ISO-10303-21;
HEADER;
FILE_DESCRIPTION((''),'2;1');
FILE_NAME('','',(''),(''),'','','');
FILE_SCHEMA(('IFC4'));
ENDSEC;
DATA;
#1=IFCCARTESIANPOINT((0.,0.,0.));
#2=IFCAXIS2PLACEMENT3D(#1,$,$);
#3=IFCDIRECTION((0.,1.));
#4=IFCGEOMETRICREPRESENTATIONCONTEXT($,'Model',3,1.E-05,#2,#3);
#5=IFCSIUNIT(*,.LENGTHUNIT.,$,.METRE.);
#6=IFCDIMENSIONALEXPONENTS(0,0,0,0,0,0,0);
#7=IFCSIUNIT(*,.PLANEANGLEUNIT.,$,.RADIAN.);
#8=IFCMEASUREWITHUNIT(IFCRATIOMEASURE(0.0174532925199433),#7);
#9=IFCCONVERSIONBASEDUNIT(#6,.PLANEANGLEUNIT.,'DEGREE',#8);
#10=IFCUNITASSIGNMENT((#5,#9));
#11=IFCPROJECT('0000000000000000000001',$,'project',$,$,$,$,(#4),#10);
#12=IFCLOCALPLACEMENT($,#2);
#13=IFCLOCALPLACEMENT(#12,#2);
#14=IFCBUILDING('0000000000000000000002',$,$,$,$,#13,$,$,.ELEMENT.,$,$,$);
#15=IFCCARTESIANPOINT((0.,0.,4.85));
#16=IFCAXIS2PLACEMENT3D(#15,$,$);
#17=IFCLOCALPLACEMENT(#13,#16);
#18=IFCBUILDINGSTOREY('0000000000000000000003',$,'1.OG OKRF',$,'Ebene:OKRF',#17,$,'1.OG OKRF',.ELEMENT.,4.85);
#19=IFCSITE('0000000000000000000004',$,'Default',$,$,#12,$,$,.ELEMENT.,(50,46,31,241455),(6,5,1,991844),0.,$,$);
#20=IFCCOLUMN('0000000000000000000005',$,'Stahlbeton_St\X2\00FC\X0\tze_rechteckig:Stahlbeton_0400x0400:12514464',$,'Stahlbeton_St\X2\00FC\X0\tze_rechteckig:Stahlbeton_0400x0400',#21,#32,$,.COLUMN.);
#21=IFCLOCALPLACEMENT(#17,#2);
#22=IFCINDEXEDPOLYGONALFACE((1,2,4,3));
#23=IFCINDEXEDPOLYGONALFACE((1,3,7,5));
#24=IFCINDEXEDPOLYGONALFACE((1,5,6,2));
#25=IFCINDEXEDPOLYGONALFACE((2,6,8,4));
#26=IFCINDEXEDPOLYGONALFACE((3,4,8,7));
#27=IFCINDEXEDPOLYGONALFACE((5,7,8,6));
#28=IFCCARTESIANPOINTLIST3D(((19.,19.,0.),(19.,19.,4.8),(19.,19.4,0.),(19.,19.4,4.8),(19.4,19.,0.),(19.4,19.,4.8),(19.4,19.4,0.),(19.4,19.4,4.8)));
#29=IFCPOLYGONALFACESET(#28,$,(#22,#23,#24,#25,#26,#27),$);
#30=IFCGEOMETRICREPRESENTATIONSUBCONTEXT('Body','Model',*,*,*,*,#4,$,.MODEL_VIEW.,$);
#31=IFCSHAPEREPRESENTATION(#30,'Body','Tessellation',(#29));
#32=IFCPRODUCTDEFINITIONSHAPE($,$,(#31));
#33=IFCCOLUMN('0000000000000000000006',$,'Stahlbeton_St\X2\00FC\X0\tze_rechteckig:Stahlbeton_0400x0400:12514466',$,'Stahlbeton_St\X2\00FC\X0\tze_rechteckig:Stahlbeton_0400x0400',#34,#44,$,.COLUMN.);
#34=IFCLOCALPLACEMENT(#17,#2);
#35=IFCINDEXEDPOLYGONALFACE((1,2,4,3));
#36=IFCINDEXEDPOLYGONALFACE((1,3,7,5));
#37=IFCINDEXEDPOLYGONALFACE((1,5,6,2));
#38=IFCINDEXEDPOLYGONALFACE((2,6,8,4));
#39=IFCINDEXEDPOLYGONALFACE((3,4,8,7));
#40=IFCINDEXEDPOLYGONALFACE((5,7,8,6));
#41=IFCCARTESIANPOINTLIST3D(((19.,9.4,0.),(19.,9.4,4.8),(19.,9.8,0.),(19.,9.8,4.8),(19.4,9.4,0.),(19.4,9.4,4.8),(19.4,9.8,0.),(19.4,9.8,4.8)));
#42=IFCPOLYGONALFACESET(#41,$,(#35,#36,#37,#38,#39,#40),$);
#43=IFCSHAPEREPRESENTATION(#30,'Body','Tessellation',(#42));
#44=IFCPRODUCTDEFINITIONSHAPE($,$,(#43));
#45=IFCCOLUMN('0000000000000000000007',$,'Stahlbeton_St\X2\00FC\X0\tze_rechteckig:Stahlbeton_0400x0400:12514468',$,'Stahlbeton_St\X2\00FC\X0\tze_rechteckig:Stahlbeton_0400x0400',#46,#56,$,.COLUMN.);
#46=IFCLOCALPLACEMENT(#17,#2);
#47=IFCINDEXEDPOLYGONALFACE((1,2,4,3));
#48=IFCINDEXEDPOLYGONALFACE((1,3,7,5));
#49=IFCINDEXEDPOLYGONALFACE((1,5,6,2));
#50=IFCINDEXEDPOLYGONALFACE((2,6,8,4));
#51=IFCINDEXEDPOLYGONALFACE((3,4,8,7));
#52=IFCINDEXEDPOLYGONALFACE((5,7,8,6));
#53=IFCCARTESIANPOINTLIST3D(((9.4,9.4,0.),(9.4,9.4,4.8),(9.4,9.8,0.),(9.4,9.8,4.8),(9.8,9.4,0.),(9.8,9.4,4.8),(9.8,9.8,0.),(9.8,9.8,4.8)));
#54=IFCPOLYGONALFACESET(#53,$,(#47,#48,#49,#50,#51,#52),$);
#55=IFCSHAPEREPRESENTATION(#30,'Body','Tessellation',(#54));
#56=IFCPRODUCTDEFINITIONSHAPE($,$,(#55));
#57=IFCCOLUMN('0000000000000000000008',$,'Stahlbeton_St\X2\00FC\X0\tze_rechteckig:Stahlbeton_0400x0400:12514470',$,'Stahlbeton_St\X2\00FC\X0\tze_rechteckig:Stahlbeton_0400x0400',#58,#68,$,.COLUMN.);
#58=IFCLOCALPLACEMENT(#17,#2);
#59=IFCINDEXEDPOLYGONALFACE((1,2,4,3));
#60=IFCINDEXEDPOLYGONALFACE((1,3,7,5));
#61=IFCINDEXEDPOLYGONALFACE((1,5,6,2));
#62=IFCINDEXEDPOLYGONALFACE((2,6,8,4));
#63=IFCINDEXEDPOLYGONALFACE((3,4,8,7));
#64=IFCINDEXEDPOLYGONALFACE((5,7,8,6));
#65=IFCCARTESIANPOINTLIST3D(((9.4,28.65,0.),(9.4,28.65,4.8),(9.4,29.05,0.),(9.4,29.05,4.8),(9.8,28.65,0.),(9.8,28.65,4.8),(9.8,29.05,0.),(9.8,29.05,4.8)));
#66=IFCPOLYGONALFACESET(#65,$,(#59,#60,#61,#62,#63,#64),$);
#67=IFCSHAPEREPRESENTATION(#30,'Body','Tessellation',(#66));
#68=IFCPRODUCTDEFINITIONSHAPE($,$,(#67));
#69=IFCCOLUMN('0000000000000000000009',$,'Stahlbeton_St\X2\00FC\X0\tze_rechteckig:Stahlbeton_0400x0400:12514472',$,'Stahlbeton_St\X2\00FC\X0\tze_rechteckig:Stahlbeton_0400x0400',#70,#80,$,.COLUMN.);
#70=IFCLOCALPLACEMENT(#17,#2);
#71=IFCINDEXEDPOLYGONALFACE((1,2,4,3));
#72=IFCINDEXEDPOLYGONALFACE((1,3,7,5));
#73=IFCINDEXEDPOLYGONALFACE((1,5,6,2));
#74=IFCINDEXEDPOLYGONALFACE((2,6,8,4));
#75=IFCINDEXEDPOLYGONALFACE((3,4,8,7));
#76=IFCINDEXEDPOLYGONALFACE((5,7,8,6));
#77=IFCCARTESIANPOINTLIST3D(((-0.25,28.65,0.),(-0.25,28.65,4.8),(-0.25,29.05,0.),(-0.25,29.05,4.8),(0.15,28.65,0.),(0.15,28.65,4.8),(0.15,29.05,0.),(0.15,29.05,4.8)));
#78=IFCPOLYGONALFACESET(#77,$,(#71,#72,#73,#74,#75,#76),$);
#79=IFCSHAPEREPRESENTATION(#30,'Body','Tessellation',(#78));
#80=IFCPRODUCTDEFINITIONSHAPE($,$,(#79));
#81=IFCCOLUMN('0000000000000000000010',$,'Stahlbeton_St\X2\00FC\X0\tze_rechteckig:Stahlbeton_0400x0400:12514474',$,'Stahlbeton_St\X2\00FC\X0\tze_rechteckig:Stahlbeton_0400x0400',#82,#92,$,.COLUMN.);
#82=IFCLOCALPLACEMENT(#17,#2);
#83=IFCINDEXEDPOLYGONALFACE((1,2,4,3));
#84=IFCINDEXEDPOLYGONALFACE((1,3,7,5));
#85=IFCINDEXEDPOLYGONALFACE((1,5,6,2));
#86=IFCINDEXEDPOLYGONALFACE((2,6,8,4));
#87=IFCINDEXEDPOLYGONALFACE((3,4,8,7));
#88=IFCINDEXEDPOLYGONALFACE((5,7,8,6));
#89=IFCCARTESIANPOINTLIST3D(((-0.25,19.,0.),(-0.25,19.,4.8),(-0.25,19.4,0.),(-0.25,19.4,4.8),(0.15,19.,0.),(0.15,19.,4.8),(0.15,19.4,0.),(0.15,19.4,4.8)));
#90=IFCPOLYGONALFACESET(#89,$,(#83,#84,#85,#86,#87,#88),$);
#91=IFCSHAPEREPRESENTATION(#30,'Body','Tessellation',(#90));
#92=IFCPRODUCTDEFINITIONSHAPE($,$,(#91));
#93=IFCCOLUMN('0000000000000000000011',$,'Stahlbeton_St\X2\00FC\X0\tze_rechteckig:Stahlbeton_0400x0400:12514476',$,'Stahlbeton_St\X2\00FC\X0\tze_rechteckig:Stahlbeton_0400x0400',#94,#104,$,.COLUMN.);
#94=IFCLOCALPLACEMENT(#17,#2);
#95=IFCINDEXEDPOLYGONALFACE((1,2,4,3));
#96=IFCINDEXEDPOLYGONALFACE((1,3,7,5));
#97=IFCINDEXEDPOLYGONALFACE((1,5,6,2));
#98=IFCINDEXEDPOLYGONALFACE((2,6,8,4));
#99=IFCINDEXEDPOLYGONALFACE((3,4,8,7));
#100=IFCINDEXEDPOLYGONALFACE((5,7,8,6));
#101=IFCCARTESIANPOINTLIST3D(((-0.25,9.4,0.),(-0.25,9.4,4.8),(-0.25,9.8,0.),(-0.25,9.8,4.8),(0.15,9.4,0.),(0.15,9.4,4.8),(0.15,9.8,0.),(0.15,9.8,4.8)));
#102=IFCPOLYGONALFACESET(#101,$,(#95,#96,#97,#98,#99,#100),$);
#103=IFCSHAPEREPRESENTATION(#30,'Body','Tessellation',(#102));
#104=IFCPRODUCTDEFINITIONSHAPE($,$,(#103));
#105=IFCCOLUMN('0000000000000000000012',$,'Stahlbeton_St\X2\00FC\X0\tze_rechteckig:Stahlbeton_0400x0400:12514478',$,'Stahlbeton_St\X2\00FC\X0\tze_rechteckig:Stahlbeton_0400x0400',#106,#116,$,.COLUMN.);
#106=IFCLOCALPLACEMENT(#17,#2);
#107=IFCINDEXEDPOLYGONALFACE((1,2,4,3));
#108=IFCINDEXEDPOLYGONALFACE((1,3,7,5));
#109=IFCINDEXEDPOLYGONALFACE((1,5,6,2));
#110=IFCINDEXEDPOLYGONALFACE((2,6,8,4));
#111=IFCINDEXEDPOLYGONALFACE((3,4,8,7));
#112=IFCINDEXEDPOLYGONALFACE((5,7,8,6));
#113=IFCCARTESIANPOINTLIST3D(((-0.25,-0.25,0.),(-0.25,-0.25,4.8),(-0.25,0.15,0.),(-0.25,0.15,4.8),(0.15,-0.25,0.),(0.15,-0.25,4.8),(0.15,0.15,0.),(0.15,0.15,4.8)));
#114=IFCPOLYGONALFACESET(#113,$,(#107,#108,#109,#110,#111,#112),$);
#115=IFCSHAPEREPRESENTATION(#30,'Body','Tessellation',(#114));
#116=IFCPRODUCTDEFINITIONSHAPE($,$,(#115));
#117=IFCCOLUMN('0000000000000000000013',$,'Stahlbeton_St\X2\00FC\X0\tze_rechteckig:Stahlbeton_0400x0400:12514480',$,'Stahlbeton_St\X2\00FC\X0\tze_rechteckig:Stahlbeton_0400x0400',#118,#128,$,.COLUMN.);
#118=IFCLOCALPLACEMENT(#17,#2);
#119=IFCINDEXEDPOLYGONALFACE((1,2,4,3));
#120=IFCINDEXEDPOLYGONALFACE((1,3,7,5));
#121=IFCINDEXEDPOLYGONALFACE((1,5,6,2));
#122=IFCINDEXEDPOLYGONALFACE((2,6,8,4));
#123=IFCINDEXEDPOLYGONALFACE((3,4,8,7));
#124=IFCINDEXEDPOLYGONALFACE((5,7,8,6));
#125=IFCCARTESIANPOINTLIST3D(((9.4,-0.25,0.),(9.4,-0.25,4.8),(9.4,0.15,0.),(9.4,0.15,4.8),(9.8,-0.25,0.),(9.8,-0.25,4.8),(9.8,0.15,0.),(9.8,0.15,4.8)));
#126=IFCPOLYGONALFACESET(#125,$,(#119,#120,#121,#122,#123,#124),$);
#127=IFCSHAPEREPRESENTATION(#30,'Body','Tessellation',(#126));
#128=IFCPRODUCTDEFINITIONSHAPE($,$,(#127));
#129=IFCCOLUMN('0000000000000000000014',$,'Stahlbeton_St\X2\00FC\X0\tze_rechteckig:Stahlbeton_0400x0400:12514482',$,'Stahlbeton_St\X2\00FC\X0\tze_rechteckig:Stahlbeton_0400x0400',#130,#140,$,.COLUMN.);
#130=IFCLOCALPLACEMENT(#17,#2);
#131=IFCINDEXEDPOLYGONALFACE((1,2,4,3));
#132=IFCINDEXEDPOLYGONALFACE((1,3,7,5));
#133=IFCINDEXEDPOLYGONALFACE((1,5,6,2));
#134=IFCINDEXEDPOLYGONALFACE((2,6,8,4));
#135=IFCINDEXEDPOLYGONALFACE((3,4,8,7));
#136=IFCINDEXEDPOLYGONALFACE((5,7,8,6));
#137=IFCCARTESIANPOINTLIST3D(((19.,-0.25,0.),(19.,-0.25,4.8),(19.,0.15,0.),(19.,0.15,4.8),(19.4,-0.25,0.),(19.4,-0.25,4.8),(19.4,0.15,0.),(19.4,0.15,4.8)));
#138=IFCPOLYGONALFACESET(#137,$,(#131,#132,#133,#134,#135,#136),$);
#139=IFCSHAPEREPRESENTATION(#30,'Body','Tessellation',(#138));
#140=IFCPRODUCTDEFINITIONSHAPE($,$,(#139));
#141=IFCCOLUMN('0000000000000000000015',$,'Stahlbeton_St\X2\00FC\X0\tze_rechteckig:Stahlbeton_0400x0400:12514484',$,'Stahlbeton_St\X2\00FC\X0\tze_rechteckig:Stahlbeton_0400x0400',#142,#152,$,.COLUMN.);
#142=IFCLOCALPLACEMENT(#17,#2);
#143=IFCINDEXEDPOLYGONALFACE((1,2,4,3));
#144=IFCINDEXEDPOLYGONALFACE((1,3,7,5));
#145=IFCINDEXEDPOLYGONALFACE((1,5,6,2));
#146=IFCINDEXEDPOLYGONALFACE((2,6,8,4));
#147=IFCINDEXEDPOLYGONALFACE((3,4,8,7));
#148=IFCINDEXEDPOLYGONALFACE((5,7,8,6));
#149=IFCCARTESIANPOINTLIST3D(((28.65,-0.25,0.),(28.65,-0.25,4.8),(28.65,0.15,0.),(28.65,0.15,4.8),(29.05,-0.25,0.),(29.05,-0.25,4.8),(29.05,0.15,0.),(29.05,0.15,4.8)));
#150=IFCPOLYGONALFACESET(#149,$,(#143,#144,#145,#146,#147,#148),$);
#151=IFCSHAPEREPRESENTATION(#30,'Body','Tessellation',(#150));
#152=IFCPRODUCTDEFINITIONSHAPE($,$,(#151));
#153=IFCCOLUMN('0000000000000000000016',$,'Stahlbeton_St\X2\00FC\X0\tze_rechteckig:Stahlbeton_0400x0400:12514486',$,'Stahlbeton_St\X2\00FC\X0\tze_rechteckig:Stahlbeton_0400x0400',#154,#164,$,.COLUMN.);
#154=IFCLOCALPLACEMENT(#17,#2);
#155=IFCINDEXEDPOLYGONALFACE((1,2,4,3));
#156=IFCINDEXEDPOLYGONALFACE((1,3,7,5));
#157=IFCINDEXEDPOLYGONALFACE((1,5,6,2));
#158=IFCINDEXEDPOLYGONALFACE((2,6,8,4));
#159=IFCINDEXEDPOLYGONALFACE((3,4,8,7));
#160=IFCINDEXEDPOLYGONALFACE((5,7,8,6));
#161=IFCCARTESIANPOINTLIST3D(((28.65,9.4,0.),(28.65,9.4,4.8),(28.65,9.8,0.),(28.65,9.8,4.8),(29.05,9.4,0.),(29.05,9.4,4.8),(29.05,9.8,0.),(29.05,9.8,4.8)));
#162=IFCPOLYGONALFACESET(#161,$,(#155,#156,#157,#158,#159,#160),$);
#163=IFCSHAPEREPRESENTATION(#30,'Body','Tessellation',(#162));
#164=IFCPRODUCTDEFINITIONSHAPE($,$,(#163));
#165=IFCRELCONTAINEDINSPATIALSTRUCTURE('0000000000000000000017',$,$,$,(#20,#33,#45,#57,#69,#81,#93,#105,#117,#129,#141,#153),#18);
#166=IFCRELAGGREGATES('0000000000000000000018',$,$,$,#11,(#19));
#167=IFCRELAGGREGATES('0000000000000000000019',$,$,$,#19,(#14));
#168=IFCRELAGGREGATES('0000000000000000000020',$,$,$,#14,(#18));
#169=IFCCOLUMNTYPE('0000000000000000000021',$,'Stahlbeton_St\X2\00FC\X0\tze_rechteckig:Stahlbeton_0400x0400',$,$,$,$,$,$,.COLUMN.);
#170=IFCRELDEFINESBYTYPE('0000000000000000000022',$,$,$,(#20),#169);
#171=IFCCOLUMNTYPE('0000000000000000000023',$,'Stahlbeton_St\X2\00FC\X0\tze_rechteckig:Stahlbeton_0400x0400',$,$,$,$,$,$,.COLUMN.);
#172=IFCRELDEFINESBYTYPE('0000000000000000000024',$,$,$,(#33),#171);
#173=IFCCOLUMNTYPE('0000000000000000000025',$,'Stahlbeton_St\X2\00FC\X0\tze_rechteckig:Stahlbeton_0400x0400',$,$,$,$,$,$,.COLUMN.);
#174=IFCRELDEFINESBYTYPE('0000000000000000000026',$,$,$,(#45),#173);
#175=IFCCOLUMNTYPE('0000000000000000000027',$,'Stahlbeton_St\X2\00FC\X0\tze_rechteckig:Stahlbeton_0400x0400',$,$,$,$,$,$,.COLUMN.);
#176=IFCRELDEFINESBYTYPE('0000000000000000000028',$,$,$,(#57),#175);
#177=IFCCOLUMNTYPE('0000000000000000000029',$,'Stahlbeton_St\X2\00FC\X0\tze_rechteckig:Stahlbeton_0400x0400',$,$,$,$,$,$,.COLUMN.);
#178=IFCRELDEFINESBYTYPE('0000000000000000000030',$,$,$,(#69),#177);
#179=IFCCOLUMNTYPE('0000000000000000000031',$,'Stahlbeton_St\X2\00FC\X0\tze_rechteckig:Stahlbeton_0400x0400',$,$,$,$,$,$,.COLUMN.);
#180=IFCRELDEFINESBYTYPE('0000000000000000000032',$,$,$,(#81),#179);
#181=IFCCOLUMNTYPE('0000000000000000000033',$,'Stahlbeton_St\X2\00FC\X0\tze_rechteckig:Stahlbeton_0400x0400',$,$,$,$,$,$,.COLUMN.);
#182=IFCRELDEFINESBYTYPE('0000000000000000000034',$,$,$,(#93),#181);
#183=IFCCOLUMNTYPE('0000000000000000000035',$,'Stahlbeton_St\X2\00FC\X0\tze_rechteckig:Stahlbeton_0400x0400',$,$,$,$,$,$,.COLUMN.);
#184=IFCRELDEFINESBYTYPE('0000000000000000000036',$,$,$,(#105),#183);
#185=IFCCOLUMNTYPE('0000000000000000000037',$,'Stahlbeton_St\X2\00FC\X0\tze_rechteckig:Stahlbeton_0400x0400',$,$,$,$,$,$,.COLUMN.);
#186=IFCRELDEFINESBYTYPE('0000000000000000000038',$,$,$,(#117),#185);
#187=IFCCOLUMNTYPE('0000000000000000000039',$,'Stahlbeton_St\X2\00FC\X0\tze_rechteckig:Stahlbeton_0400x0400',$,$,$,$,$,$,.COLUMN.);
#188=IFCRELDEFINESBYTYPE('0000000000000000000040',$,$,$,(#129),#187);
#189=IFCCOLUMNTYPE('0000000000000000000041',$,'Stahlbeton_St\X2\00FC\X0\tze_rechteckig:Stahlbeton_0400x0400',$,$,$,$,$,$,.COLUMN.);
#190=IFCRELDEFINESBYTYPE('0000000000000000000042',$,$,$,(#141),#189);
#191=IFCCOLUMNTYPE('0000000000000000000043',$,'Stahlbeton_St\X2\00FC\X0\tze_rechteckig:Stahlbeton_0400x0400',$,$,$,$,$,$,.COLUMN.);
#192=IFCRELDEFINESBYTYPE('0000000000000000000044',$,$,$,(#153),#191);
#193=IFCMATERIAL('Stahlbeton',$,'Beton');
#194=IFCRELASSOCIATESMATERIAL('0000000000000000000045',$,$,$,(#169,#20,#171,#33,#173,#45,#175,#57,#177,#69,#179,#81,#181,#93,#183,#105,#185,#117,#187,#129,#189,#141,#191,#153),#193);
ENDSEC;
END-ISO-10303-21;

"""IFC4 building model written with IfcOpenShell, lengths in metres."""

from ifc_helpers import new_model, entity, si_unit, converted_unit, direction, frame, origin, place, context, subcontext, project, spatial, indexed_curve, outline, extrude, source, transform, mapped, material, type_object, type_shapes, element, save


model = new_model("IFC4")

# Units and contexts
model_context = context("Model", 3, precision=1e-05, world=origin(), true_north=direction((0.0, 1.0)))
body_context = subcontext(model_context, "Body", "Model", "MODEL_VIEW")
ifc_project = project(units=[si_unit("LENGTHUNIT", "METRE"), converted_unit("PLANEANGLEUNIT", "DEGREE", entity("IfcRatioMeasure", 0.0174532925199433), si_unit("PLANEANGLEUNIT", "RADIAN"), dimensions=[0, 0, 0, 0, 0, 0, 0])], contexts=[model_context])

# Site, building, storey
site_placement = place(None, origin())
site = spatial("IfcSite", under=ifc_project, at=site_placement, Name="Default", CompositionType="ELEMENT", RefLatitude=(50, 46, 31, 241455), RefLongitude=(6, 5, 1, 991844), RefElevation=0.0)
building_placement = place(site_placement, origin())
building = spatial("IfcBuilding", under=site, at=building_placement, CompositionType="ELEMENT")
storey_placement = place(building_placement, frame((0.0, 0.0, 4.85)))
storey = spatial("IfcBuildingStorey", under=building, at=storey_placement, Name="1.OG OKRF", ObjectType="Ebene:OKRF", LongName="1.OG OKRF", CompositionType="ELEMENT", Elevation=4.85)

# Columns
ifc_material_1 = material(Name="Stahlbeton", Category="Beton")
column_type_1 = type_object("IfcColumnType", Name="Stahlbeton_Stütze_rechteckig:Stahlbeton_0400x0400", PredefinedType="COLUMN", material=ifc_material_1)
shared_shape_1 = source(origin(), body_context, "Body", "SweptSolid", [
    extrude(outline(indexed_curve([(-0.2, -0.2), (0.2, -0.2), (0.2, 0.2), (-0.2, 0.2), (-0.2, -0.2)], self_intersect=False)), frame((19.2, 19.2, 4.85), z_axis=(0.0, 0.0, 1.0), x_axis=(0.0, -1.0, 0.0)), (0.0, 0.0, 1.0), 4.8),
])
type_shapes(column_type_1, [shared_shape_1])
column_1_placement = place(storey_placement, frame((0.0, 0.0, -4.85)))
element("IfcColumn", 1, at=column_1_placement, inside=storey, type_object=column_type_1, material=ifc_material_1, Name="Stahlbeton_Stütze_rechteckig:Stahlbeton_0400x0400:12514464", ObjectType="Stahlbeton_Stütze_rechteckig:Stahlbeton_0400x0400", PredefinedType="COLUMN", context=body_context, shape_type="MappedRepresentation", body=[
    mapped(shared_shape_1, transform((0.0, 0.0, 0.0), scale=1.0)),
])
column_type_2 = type_object("IfcColumnType", Name="Stahlbeton_Stütze_rechteckig:Stahlbeton_0400x0400", PredefinedType="COLUMN", material=ifc_material_1)
shared_shape_2 = source(origin(), body_context, "Body", "SweptSolid", [
    extrude(outline(indexed_curve([(-0.2, -0.2), (0.2, -0.2), (0.2, 0.2), (-0.2, 0.2), (-0.2, -0.2)], self_intersect=False)), frame((19.2, 9.6, 4.85), z_axis=(0.0, 0.0, 1.0), x_axis=(0.0, -1.0, 0.0)), (0.0, 0.0, 1.0), 4.8),
])
type_shapes(column_type_2, [shared_shape_2])
column_2_placement = place(storey_placement, frame((0.0, 0.0, -4.85)))
element("IfcColumn", 2, at=column_2_placement, inside=storey, type_object=column_type_2, material=ifc_material_1, Name="Stahlbeton_Stütze_rechteckig:Stahlbeton_0400x0400:12514466", ObjectType="Stahlbeton_Stütze_rechteckig:Stahlbeton_0400x0400", PredefinedType="COLUMN", context=body_context, shape_type="MappedRepresentation", body=[
    mapped(shared_shape_2, transform((0.0, 0.0, 0.0), scale=1.0)),
])
column_type_3 = type_object("IfcColumnType", Name="Stahlbeton_Stütze_rechteckig:Stahlbeton_0400x0400", PredefinedType="COLUMN", material=ifc_material_1)
shared_shape_3 = source(origin(), body_context, "Body", "SweptSolid", [
    extrude(outline(indexed_curve([(-0.2, -0.2), (0.2, -0.2), (0.2, 0.2), (-0.2, 0.2), (-0.2, -0.2)], self_intersect=False)), frame((9.6, 9.6, 4.85), z_axis=(0.0, 0.0, 1.0), x_axis=(0.0, -1.0, 0.0)), (0.0, 0.0, 1.0), 4.8),
])
type_shapes(column_type_3, [shared_shape_3])
column_3_placement = place(storey_placement, frame((0.0, 0.0, -4.85)))
element("IfcColumn", 3, at=column_3_placement, inside=storey, type_object=column_type_3, material=ifc_material_1, Name="Stahlbeton_Stütze_rechteckig:Stahlbeton_0400x0400:12514468", ObjectType="Stahlbeton_Stütze_rechteckig:Stahlbeton_0400x0400", PredefinedType="COLUMN", context=body_context, shape_type="MappedRepresentation", body=[
    mapped(shared_shape_3, transform((0.0, 0.0, 0.0), scale=1.0)),
])
column_type_4 = type_object("IfcColumnType", Name="Stahlbeton_Stütze_rechteckig:Stahlbeton_0400x0400", PredefinedType="COLUMN", material=ifc_material_1)
shared_shape_4 = source(origin(), body_context, "Body", "SweptSolid", [
    extrude(outline(indexed_curve([(-0.2, -0.2), (0.2, -0.2), (0.2, 0.2), (-0.2, 0.2), (-0.2, -0.2)], self_intersect=False)), frame((9.6, 28.85, 4.85), z_axis=(0.0, 0.0, 1.0), x_axis=(0.0, -1.0, 0.0)), (0.0, 0.0, 1.0), 4.8),
])
type_shapes(column_type_4, [shared_shape_4])
column_4_placement = place(storey_placement, frame((0.0, 0.0, -4.85)))
element("IfcColumn", 4, at=column_4_placement, inside=storey, type_object=column_type_4, material=ifc_material_1, Name="Stahlbeton_Stütze_rechteckig:Stahlbeton_0400x0400:12514470", ObjectType="Stahlbeton_Stütze_rechteckig:Stahlbeton_0400x0400", PredefinedType="COLUMN", context=body_context, shape_type="MappedRepresentation", body=[
    mapped(shared_shape_4, transform((0.0, 0.0, 0.0), scale=1.0)),
])
column_type_5 = type_object("IfcColumnType", Name="Stahlbeton_Stütze_rechteckig:Stahlbeton_0400x0400", PredefinedType="COLUMN", material=ifc_material_1)
shared_shape_5 = source(origin(), body_context, "Body", "SweptSolid", [
    extrude(outline(indexed_curve([(-0.2, -0.2), (0.2, -0.2), (0.2, 0.2), (-0.2, 0.2), (-0.2, -0.2)], self_intersect=False)), frame((-0.05, 28.85, 4.85), z_axis=(0.0, 0.0, 1.0), x_axis=(0.0, -1.0, 0.0)), (0.0, 0.0, 1.0), 4.8),
])
type_shapes(column_type_5, [shared_shape_5])
column_5_placement = place(storey_placement, frame((0.0, 0.0, -4.85)))
element("IfcColumn", 5, at=column_5_placement, inside=storey, type_object=column_type_5, material=ifc_material_1, Name="Stahlbeton_Stütze_rechteckig:Stahlbeton_0400x0400:12514472", ObjectType="Stahlbeton_Stütze_rechteckig:Stahlbeton_0400x0400", PredefinedType="COLUMN", context=body_context, shape_type="MappedRepresentation", body=[
    mapped(shared_shape_5, transform((0.0, 0.0, 0.0), scale=1.0)),
])
column_type_6 = type_object("IfcColumnType", Name="Stahlbeton_Stütze_rechteckig:Stahlbeton_0400x0400", PredefinedType="COLUMN", material=ifc_material_1)
shared_shape_6 = source(origin(), body_context, "Body", "SweptSolid", [
    extrude(outline(indexed_curve([(-0.2, -0.2), (0.2, -0.2), (0.2, 0.2), (-0.2, 0.2), (-0.2, -0.2)], self_intersect=False)), frame((-0.05, 19.2, 4.85), z_axis=(0.0, 0.0, 1.0), x_axis=(0.0, -1.0, 0.0)), (0.0, 0.0, 1.0), 4.8),
])
type_shapes(column_type_6, [shared_shape_6])
column_6_placement = place(storey_placement, frame((0.0, 0.0, -4.85)))
element("IfcColumn", 6, at=column_6_placement, inside=storey, type_object=column_type_6, material=ifc_material_1, Name="Stahlbeton_Stütze_rechteckig:Stahlbeton_0400x0400:12514474", ObjectType="Stahlbeton_Stütze_rechteckig:Stahlbeton_0400x0400", PredefinedType="COLUMN", context=body_context, shape_type="MappedRepresentation", body=[
    mapped(shared_shape_6, transform((0.0, 0.0, 0.0), scale=1.0)),
])
column_type_7 = type_object("IfcColumnType", Name="Stahlbeton_Stütze_rechteckig:Stahlbeton_0400x0400", PredefinedType="COLUMN", material=ifc_material_1)
shared_shape_7 = source(origin(), body_context, "Body", "SweptSolid", [
    extrude(outline(indexed_curve([(-0.2, -0.2), (0.2, -0.2), (0.2, 0.2), (-0.2, 0.2), (-0.2, -0.2)], self_intersect=False)), frame((-0.05, 9.6, 4.85), z_axis=(0.0, 0.0, 1.0), x_axis=(0.0, -1.0, 0.0)), (0.0, 0.0, 1.0), 4.8),
])
type_shapes(column_type_7, [shared_shape_7])
column_7_placement = place(storey_placement, frame((0.0, 0.0, -4.85)))
element("IfcColumn", 7, at=column_7_placement, inside=storey, type_object=column_type_7, material=ifc_material_1, Name="Stahlbeton_Stütze_rechteckig:Stahlbeton_0400x0400:12514476", ObjectType="Stahlbeton_Stütze_rechteckig:Stahlbeton_0400x0400", PredefinedType="COLUMN", context=body_context, shape_type="MappedRepresentation", body=[
    mapped(shared_shape_7, transform((0.0, 0.0, 0.0), scale=1.0)),
])
column_type_8 = type_object("IfcColumnType", Name="Stahlbeton_Stütze_rechteckig:Stahlbeton_0400x0400", PredefinedType="COLUMN", material=ifc_material_1)
shared_shape_8 = source(origin(), body_context, "Body", "SweptSolid", [
    extrude(outline(indexed_curve([(-0.2, -0.2), (0.2, -0.2), (0.2, 0.2), (-0.2, 0.2), (-0.2, -0.2)], self_intersect=False)), frame((-0.05, -0.05, 4.85), z_axis=(0.0, 0.0, 1.0), x_axis=(0.0, -1.0, 0.0)), (0.0, 0.0, 1.0), 4.8),
])
type_shapes(column_type_8, [shared_shape_8])
column_8_placement = place(storey_placement, frame((0.0, 0.0, -4.85)))
element("IfcColumn", 8, at=column_8_placement, inside=storey, type_object=column_type_8, material=ifc_material_1, Name="Stahlbeton_Stütze_rechteckig:Stahlbeton_0400x0400:12514478", ObjectType="Stahlbeton_Stütze_rechteckig:Stahlbeton_0400x0400", PredefinedType="COLUMN", context=body_context, shape_type="MappedRepresentation", body=[
    mapped(shared_shape_8, transform((0.0, 0.0, 0.0), scale=1.0)),
])
column_type_9 = type_object("IfcColumnType", Name="Stahlbeton_Stütze_rechteckig:Stahlbeton_0400x0400", PredefinedType="COLUMN", material=ifc_material_1)
shared_shape_9 = source(origin(), body_context, "Body", "SweptSolid", [
    extrude(outline(indexed_curve([(-0.2, -0.2), (0.2, -0.2), (0.2, 0.2), (-0.2, 0.2), (-0.2, -0.2)], self_intersect=False)), frame((9.6, -0.05, 4.85), z_axis=(0.0, 0.0, 1.0), x_axis=(0.0, -1.0, 0.0)), (0.0, 0.0, 1.0), 4.8),
])
type_shapes(column_type_9, [shared_shape_9])
column_9_placement = place(storey_placement, frame((0.0, 0.0, -4.85)))
element("IfcColumn", 9, at=column_9_placement, inside=storey, type_object=column_type_9, material=ifc_material_1, Name="Stahlbeton_Stütze_rechteckig:Stahlbeton_0400x0400:12514480", ObjectType="Stahlbeton_Stütze_rechteckig:Stahlbeton_0400x0400", PredefinedType="COLUMN", context=body_context, shape_type="MappedRepresentation", body=[
    mapped(shared_shape_9, transform((0.0, 0.0, 0.0), scale=1.0)),
])
column_type_10 = type_object("IfcColumnType", Name="Stahlbeton_Stütze_rechteckig:Stahlbeton_0400x0400", PredefinedType="COLUMN", material=ifc_material_1)
shared_shape_10 = source(origin(), body_context, "Body", "SweptSolid", [
    extrude(outline(indexed_curve([(-0.2, -0.2), (0.2, -0.2), (0.2, 0.2), (-0.2, 0.2), (-0.2, -0.2)], self_intersect=False)), frame((19.2, -0.05, 4.85), z_axis=(0.0, 0.0, 1.0), x_axis=(0.0, -1.0, 0.0)), (0.0, 0.0, 1.0), 4.8),
])
type_shapes(column_type_10, [shared_shape_10])
column_10_placement = place(storey_placement, frame((0.0, 0.0, -4.85)))
element("IfcColumn", 10, at=column_10_placement, inside=storey, type_object=column_type_10, material=ifc_material_1, Name="Stahlbeton_Stütze_rechteckig:Stahlbeton_0400x0400:12514482", ObjectType="Stahlbeton_Stütze_rechteckig:Stahlbeton_0400x0400", PredefinedType="COLUMN", context=body_context, shape_type="MappedRepresentation", body=[
    mapped(shared_shape_10, transform((0.0, 0.0, 0.0), scale=1.0)),
])
column_type_11 = type_object("IfcColumnType", Name="Stahlbeton_Stütze_rechteckig:Stahlbeton_0400x0400", PredefinedType="COLUMN", material=ifc_material_1)
shared_shape_11 = source(origin(), body_context, "Body", "SweptSolid", [
    extrude(outline(indexed_curve([(-0.2, -0.2), (0.2, -0.2), (0.2, 0.2), (-0.2, 0.2), (-0.2, -0.2)], self_intersect=False)), frame((28.85, -0.05, 4.85), z_axis=(0.0, 0.0, 1.0), x_axis=(0.0, -1.0, 0.0)), (0.0, 0.0, 1.0), 4.8),
])
type_shapes(column_type_11, [shared_shape_11])
column_11_placement = place(storey_placement, frame((0.0, 0.0, -4.85)))
element("IfcColumn", 11, at=column_11_placement, inside=storey, type_object=column_type_11, material=ifc_material_1, Name="Stahlbeton_Stütze_rechteckig:Stahlbeton_0400x0400:12514484", ObjectType="Stahlbeton_Stütze_rechteckig:Stahlbeton_0400x0400", PredefinedType="COLUMN", context=body_context, shape_type="MappedRepresentation", body=[
    mapped(shared_shape_11, transform((0.0, 0.0, 0.0), scale=1.0)),
])
column_type_12 = type_object("IfcColumnType", Name="Stahlbeton_Stütze_rechteckig:Stahlbeton_0400x0400", PredefinedType="COLUMN", material=ifc_material_1)
shared_shape_12 = source(origin(), body_context, "Body", "SweptSolid", [
    extrude(outline(indexed_curve([(-0.2, -0.2), (0.2, -0.2), (0.2, 0.2), (-0.2, 0.2), (-0.2, -0.2)], self_intersect=False)), frame((28.85, 9.6, 4.85), z_axis=(0.0, 0.0, 1.0), x_axis=(0.0, -1.0, 0.0)), (0.0, 0.0, 1.0), 4.8),
])
type_shapes(column_type_12, [shared_shape_12])
column_12_placement = place(storey_placement, frame((0.0, 0.0, -4.85)))
element("IfcColumn", 12, at=column_12_placement, inside=storey, type_object=column_type_12, material=ifc_material_1, Name="Stahlbeton_Stütze_rechteckig:Stahlbeton_0400x0400:12514486", ObjectType="Stahlbeton_Stütze_rechteckig:Stahlbeton_0400x0400", PredefinedType="COLUMN", context=body_context, shape_type="MappedRepresentation", body=[
    mapped(shared_shape_12, transform((0.0, 0.0, 0.0), scale=1.0)),
])

save(model, "model.ifc")
